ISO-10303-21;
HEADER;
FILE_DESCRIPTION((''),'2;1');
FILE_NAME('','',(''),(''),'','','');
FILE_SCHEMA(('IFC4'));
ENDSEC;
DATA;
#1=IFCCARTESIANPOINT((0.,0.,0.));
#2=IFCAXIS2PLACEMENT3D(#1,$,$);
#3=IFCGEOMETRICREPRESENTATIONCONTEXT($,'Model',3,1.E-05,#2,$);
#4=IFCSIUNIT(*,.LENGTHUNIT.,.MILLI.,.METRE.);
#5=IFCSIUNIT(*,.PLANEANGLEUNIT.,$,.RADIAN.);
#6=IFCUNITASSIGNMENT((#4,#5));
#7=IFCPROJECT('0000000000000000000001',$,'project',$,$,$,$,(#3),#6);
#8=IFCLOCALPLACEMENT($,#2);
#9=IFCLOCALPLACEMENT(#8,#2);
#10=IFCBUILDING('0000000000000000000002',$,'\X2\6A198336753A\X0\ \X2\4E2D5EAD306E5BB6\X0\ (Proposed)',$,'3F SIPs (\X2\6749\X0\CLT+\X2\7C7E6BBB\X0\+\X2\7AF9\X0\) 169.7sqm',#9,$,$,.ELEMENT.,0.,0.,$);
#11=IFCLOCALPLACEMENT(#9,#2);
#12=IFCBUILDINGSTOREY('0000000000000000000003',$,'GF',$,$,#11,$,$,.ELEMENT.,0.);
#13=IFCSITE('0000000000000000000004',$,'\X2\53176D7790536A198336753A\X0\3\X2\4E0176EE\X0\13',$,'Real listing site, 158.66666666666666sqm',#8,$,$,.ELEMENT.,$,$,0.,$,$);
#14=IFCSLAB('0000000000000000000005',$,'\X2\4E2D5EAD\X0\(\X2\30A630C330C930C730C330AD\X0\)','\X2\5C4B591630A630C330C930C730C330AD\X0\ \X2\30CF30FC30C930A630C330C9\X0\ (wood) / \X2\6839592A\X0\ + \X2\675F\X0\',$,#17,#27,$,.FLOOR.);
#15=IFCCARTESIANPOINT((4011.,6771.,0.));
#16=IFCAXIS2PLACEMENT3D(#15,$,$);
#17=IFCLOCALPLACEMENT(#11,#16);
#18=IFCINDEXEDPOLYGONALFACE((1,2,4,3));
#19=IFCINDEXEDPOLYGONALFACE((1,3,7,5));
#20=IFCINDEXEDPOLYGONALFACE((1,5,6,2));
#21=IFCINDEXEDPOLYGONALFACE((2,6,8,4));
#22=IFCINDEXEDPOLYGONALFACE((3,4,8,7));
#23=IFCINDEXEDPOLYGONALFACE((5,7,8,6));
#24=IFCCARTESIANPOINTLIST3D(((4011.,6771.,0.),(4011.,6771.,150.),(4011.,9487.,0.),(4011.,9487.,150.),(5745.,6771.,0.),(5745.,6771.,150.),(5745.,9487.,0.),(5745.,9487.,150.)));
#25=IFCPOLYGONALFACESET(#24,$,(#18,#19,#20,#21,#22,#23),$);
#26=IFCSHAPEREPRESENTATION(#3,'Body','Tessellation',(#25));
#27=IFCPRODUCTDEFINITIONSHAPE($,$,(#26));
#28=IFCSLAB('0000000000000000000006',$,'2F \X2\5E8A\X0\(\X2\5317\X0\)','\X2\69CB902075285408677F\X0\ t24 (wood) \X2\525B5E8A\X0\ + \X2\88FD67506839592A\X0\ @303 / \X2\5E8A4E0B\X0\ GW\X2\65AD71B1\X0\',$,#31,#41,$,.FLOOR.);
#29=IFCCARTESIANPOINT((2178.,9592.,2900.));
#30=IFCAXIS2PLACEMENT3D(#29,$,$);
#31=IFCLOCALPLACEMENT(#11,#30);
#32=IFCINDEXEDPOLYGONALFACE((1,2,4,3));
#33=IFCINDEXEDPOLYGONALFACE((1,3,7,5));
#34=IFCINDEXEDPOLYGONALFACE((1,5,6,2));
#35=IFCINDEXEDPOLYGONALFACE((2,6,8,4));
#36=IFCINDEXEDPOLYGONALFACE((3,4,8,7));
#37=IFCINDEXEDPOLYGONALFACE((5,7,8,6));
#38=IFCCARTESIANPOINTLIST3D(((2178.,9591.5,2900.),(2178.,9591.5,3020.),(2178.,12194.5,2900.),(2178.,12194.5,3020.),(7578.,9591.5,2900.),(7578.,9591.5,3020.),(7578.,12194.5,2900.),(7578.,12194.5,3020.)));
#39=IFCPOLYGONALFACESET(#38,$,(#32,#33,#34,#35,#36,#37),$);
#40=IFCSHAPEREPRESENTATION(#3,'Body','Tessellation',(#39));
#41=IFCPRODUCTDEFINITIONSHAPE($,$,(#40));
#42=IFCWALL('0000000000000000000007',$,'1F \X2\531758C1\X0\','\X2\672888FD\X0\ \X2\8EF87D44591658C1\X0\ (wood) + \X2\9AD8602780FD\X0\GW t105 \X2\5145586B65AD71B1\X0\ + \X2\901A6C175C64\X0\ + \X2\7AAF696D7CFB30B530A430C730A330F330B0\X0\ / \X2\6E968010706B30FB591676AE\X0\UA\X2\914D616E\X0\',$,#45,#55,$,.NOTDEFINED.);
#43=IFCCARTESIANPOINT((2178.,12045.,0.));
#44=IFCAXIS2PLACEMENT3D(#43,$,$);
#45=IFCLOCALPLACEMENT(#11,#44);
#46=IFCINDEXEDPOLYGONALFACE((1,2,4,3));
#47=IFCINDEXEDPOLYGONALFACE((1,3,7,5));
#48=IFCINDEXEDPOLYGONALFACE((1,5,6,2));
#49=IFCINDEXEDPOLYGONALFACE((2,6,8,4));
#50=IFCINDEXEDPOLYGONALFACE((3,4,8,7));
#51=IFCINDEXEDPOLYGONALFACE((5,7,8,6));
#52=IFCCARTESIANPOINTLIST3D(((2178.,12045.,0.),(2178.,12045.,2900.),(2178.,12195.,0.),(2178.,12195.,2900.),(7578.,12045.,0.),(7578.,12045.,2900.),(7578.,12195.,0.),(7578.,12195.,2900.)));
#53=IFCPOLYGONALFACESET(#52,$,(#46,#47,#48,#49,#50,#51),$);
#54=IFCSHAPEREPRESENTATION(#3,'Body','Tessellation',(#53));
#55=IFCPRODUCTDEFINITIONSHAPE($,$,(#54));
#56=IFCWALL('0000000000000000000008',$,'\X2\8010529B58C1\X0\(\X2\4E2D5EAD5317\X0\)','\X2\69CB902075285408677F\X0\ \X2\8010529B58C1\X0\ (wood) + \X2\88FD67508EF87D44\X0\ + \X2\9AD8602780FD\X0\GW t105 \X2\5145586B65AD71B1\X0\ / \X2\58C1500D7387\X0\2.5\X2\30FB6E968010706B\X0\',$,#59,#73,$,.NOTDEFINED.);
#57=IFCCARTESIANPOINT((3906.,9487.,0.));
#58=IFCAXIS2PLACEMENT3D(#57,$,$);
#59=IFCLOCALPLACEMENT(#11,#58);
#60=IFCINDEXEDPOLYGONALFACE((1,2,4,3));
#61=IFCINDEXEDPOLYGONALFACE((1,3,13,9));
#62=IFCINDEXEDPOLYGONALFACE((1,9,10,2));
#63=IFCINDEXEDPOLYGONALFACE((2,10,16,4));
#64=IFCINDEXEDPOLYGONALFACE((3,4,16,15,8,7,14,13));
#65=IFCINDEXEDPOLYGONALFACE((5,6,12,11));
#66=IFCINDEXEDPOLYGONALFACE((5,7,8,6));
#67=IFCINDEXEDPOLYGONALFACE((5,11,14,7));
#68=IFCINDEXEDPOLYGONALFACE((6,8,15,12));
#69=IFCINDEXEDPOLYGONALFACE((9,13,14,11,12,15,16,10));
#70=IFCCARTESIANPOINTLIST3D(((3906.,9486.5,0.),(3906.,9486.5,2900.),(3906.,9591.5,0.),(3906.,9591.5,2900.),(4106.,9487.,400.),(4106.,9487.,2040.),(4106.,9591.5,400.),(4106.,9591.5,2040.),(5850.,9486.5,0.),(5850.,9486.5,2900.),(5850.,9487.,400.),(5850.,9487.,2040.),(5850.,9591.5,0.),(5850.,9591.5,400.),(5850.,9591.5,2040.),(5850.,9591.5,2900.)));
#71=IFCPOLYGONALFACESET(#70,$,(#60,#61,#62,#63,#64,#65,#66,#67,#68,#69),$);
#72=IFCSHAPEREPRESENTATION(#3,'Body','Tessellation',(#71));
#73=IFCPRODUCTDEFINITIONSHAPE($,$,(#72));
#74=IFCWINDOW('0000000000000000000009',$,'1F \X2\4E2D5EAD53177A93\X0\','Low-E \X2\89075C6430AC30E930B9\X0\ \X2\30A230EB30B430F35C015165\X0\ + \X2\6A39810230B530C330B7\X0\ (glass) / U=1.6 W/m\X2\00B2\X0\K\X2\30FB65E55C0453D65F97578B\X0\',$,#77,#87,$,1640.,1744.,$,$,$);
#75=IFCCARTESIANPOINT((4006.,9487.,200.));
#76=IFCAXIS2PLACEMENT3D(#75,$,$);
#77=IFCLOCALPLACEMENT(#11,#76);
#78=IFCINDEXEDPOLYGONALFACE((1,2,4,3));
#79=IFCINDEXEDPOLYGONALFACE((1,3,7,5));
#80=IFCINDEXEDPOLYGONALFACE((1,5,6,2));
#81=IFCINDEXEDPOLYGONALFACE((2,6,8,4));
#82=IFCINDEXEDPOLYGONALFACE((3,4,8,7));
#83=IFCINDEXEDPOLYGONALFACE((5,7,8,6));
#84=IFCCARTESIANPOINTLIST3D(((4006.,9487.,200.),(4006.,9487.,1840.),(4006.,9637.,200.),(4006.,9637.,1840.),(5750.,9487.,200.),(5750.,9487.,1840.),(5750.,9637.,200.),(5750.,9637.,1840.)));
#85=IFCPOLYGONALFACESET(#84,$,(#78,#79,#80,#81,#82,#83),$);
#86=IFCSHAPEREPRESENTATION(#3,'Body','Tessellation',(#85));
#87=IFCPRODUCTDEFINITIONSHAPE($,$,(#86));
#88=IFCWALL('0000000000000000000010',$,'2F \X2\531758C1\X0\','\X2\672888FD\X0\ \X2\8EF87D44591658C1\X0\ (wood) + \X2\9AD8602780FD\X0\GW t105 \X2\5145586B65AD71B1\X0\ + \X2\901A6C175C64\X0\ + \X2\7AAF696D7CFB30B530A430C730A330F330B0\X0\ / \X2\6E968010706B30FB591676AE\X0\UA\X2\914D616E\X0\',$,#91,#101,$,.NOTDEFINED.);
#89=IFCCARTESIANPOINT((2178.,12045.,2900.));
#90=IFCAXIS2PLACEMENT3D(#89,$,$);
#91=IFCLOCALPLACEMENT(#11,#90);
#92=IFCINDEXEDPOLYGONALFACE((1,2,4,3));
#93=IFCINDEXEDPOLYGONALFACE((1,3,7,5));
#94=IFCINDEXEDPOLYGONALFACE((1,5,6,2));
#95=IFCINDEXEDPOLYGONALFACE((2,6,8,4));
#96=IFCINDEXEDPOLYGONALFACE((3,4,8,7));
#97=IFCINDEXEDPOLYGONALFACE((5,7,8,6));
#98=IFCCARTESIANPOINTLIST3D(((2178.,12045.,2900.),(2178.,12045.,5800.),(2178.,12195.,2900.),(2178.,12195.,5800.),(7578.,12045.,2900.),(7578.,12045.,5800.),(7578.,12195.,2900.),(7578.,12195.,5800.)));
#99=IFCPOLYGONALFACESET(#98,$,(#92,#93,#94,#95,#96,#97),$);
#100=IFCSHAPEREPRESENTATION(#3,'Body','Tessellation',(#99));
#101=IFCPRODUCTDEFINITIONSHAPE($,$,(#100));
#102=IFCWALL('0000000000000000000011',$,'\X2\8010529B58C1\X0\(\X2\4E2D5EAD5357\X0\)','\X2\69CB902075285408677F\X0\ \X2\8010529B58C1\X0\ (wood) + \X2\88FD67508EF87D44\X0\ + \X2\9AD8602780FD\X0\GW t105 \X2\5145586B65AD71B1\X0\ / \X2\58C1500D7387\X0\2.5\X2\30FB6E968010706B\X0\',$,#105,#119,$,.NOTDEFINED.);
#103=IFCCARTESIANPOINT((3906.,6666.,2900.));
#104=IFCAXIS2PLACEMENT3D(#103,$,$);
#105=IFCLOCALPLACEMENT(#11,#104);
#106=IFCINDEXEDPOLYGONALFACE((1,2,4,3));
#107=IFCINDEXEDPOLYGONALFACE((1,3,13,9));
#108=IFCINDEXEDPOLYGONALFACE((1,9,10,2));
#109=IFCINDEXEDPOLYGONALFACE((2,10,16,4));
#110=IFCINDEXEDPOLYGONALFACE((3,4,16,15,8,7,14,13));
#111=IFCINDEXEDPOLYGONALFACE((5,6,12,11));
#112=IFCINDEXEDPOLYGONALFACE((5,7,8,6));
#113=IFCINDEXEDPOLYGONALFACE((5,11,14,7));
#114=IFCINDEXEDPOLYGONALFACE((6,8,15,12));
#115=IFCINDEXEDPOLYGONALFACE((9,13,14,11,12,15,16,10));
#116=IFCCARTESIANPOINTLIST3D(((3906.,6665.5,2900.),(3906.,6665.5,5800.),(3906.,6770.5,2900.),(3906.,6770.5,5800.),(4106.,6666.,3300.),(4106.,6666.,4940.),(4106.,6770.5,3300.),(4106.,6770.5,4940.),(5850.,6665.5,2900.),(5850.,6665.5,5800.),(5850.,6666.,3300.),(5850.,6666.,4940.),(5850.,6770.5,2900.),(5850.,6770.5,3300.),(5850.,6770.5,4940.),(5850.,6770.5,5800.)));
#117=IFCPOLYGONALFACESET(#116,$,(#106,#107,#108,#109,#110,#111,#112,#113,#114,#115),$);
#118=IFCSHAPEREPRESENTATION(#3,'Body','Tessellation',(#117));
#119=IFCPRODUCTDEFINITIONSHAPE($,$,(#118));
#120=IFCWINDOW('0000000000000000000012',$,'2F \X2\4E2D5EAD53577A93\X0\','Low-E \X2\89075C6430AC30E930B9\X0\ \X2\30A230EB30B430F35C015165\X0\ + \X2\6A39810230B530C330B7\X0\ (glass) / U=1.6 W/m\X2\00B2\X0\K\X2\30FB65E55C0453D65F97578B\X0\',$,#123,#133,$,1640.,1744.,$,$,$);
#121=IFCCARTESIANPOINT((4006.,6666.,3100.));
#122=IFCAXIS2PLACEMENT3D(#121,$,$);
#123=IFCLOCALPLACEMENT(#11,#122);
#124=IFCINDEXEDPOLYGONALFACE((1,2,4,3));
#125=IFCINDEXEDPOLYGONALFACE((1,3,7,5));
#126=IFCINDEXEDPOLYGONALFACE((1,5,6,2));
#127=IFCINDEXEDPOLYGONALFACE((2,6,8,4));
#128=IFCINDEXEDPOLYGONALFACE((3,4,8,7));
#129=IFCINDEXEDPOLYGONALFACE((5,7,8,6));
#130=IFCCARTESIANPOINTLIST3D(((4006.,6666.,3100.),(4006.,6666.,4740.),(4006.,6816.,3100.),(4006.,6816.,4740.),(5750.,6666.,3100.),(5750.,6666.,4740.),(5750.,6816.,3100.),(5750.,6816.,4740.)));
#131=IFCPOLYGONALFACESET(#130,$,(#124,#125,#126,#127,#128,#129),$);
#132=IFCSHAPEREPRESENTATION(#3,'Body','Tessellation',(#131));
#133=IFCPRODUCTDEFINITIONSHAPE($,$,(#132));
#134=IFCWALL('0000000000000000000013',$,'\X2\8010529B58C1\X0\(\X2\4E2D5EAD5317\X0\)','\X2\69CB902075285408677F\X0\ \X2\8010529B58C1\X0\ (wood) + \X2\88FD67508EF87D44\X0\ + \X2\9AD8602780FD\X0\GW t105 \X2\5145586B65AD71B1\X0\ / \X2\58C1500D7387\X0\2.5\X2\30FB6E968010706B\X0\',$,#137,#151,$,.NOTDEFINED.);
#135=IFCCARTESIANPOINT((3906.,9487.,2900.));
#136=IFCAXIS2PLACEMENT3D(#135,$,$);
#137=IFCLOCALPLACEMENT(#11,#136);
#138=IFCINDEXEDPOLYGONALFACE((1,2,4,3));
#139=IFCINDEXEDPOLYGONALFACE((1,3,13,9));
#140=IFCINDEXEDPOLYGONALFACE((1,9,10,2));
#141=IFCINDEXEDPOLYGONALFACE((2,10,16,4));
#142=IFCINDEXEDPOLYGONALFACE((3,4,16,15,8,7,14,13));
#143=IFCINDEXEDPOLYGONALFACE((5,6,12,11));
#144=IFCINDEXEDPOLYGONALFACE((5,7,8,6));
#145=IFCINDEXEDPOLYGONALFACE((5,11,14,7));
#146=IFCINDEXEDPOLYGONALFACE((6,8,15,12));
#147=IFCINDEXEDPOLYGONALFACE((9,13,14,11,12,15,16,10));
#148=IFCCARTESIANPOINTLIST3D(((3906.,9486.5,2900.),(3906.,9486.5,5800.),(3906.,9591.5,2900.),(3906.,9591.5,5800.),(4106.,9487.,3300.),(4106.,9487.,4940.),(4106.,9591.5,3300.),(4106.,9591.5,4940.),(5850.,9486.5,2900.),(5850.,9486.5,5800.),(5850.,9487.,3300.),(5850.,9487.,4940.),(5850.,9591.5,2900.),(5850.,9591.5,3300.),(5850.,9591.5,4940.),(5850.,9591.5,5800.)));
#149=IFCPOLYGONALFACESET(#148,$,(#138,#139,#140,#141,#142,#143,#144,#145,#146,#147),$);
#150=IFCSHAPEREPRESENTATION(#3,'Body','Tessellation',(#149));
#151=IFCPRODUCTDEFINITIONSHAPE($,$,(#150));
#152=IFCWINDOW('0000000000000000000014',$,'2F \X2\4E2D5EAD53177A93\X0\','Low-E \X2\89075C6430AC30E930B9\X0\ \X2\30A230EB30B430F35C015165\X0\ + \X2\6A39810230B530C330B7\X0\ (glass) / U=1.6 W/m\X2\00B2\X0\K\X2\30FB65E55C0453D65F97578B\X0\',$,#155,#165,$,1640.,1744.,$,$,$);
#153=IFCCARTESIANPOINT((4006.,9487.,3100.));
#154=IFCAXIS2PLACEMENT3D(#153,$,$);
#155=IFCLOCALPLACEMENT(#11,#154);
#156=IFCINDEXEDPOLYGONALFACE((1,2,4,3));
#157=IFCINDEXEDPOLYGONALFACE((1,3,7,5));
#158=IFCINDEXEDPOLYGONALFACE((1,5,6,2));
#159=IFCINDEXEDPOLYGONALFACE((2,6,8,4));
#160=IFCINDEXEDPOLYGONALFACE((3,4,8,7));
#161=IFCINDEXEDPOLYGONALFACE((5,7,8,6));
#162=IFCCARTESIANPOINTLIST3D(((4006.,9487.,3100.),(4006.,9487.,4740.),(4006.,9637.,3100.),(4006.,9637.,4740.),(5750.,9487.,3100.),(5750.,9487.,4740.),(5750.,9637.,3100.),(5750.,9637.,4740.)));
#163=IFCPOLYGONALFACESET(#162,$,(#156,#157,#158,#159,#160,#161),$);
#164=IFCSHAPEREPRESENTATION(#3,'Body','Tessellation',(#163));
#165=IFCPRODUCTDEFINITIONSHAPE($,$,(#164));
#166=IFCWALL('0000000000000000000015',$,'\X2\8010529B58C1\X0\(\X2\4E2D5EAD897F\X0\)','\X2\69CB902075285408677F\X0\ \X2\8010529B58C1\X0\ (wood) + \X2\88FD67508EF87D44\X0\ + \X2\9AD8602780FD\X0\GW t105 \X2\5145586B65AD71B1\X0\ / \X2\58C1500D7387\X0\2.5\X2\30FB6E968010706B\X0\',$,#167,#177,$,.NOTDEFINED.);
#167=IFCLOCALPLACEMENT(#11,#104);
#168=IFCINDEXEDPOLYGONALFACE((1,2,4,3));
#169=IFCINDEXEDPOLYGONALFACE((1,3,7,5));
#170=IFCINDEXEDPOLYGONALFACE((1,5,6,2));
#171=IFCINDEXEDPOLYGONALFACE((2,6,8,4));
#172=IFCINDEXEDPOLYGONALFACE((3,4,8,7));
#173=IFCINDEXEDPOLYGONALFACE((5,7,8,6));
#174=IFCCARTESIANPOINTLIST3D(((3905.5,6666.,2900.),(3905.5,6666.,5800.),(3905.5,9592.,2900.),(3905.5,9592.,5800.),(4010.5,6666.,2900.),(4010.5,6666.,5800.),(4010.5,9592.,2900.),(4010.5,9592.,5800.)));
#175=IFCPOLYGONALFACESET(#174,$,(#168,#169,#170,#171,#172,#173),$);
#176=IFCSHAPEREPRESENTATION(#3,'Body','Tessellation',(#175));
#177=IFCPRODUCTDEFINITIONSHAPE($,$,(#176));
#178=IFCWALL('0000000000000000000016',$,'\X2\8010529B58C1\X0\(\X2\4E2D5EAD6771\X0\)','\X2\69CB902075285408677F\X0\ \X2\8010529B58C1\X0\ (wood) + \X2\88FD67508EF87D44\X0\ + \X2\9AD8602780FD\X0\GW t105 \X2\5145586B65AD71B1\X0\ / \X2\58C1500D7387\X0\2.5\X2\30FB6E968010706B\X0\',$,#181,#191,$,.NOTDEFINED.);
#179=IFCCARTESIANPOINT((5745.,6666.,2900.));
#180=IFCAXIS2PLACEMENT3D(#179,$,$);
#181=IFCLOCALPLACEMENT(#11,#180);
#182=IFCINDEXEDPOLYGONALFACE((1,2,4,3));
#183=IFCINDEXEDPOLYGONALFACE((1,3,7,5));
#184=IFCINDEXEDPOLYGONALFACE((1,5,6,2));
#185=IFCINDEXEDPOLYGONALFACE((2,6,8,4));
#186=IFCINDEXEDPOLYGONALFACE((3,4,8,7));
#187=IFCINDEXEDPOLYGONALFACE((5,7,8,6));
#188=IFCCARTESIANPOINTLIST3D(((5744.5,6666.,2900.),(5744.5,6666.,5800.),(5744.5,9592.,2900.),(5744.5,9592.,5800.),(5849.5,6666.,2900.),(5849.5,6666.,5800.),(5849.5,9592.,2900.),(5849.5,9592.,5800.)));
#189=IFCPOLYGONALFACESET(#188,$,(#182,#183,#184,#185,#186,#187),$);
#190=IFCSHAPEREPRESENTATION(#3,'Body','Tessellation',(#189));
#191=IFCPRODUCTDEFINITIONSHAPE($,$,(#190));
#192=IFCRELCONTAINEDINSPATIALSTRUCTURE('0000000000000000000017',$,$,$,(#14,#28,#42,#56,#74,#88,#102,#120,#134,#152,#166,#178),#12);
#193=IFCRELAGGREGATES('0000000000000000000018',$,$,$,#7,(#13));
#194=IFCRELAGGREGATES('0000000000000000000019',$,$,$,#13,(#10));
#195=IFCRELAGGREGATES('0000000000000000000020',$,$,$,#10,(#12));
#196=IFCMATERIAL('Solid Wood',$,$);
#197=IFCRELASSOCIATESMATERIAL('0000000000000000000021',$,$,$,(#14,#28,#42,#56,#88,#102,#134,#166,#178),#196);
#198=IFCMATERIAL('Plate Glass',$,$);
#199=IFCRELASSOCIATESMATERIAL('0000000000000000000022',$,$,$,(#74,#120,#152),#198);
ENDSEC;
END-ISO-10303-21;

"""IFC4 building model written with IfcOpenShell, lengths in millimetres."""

from ifc_helpers import new_model, si_unit, frame, frame_2d, origin, place, context, project, spatial, rectangle, extrude, material, element, fill, save


model = new_model("IFC4")

# Units and contexts
model_context = context("Model", 3, precision=1e-05, world=origin())
ifc_project = project(units=[si_unit("LENGTHUNIT", "METRE", prefix="MILLI"), si_unit("PLANEANGLEUNIT", "RADIAN")], contexts=[model_context])

# Site, building, storey
site_placement = place(None, origin())
site = spatial("IfcSite", under=ifc_project, at=site_placement, Name="北海道標茶町3丁目13", ObjectType="Real listing site, 158.66666666666666sqm", CompositionType="ELEMENT", RefElevation=0.0)
building_placement = place(site_placement, origin())
building = spatial("IfcBuilding", under=site, at=building_placement, Name="標茶町 中庭の家 (Proposed)", ObjectType="3F SIPs (杉CLT+籾殻+竹) 169.7sqm", CompositionType="ELEMENT", ElevationOfRefHeight=0.0, ElevationOfTerrain=0.0)
storey_placement = place(building_placement, origin())
storey = spatial("IfcBuildingStorey", under=building, at=storey_placement, Name="GF", CompositionType="ELEMENT", Elevation=0.0)

# Slabs
ifc_material_1 = material(Name="Solid Wood")
slab_1_placement = place(storey_placement, frame((4011.0, 6771.0, 0.0)))
element("IfcSlab", 1, at=slab_1_placement, inside=storey, material=ifc_material_1, Name="中庭(ウッドデッキ)", Description="屋外ウッドデッキ ハードウッド (wood) / 根太 + 束", PredefinedType="FLOOR", context=model_context, shape_type="SweptSolid", body=[
    extrude(rectangle(XDim=1734.0, YDim=2716.0, at=frame_2d((867.0, 1358.0))), frame((4011.0, 6771.0, 0.0)), (0.0, 0.0, 1.0), 150.0),
])
slab_2_placement = place(storey_placement, frame((2178.0, 9592.0, 2900.0)))
element("IfcSlab", 2, at=slab_2_placement, inside=storey, material=ifc_material_1, Name="2F 床(北)", Description="構造用合板 t24 (wood) 剛床 + 製材根太 @303 / 床下 GW断熱", PredefinedType="FLOOR", context=model_context, shape_type="SweptSolid", body=[
    extrude(rectangle(XDim=5400.0, YDim=2603.0, at=frame_2d((2700.0, 1301.0))), frame((2178.0, 9592.0, 2900.0)), (0.0, 0.0, 1.0), 120.0),
])

# Wall
wall_1_placement = place(storey_placement, frame((2178.0, 12045.0, 0.0)))
element("IfcWall", 3, at=wall_1_placement, inside=storey, material=ifc_material_1, Name="1F 北壁", Description="木製 軸組外壁 (wood) + 高性能GW t105 充填断熱 + 通気層 + 窯業系サイディング / 準耐火・外皮UA配慮", PredefinedType="NOTDEFINED", context=model_context, shape_type="SweptSolid", body=[
    extrude(rectangle(XDim=5400.0, YDim=150.0, at=frame_2d((2700.0, 75.0))), frame((2178.0, 12045.0, 0.0)), (0.0, 0.0, 1.0), 2900.0),
])

# Wall, opening, window
wall_2_placement = place(storey_placement, frame((3906.0, 9487.0, 0.0)))
wall_2 = element("IfcWall", 4, at=wall_2_placement, inside=storey, material=ifc_material_1, Name="耐力壁(中庭北)", Description="構造用合板 耐力壁 (wood) + 製材軸組 + 高性能GW t105 充填断熱 / 壁倍率2.5・準耐火", PredefinedType="NOTDEFINED", context=model_context, shape_type="SweptSolid", body=[
    extrude(rectangle(XDim=1944.0, YDim=105.0, at=frame_2d((972.0, 52.0))), frame((3906.0, 9487.0, 0.0)), (0.0, 0.0, 1.0), 2900.0),
])
opening_1_placement = place(storey_placement, frame((4006.0, 9487.0, 200.0)))
opening_1 = element("IfcOpeningElement", 5, at=opening_1_placement, cuts=wall_2, PredefinedType="NOTDEFINED", context=model_context, shape_type="SweptSolid", body=[
    extrude(rectangle(XDim=1744.0, YDim=150.0, at=frame_2d((872.0, 75.0))), frame((4006.0, 9487.0, 200.0)), (0.0, 0.0, 1.0), 1640.0),
])
ifc_material_2 = material(Name="Plate Glass")
window_1_placement = place(storey_placement, frame((4006.0, 9487.0, 200.0)))
window_1 = element("IfcWindow", 6, at=window_1_placement, inside=storey, material=ifc_material_2, Name="1F 中庭北窓", Description="Low-E 複層ガラス アルゴン封入 + 樹脂サッシ (glass) / U=1.6 W/m²K・日射取得型", OverallHeight=1640.0, OverallWidth=1744.0, context=model_context, shape_type="SweptSolid", body=[
    extrude(rectangle(XDim=1744.0, YDim=150.0, at=frame_2d((872.0, 75.0))), frame((4006.0, 9487.0, 200.0)), (0.0, 0.0, 1.0), 1640.0),
])
fill(opening_1, window_1)

# Wall
wall_3_placement = place(storey_placement, frame((2178.0, 12045.0, 2900.0)))
element("IfcWall", 7, at=wall_3_placement, inside=storey, material=ifc_material_1, Name="2F 北壁", Description="木製 軸組外壁 (wood) + 高性能GW t105 充填断熱 + 通気層 + 窯業系サイディング / 準耐火・外皮UA配慮", PredefinedType="NOTDEFINED", context=model_context, shape_type="SweptSolid", body=[
    extrude(rectangle(XDim=5400.0, YDim=150.0, at=frame_2d((2700.0, 75.0))), frame((2178.0, 12045.0, 2900.0)), (0.0, 0.0, 1.0), 2900.0),
])

# Walls, openings, windows
wall_4_placement = place(storey_placement, frame((3906.0, 6666.0, 2900.0)))
wall_4 = element("IfcWall", 8, at=wall_4_placement, inside=storey, material=ifc_material_1, Name="耐力壁(中庭南)", Description="構造用合板 耐力壁 (wood) + 製材軸組 + 高性能GW t105 充填断熱 / 壁倍率2.5・準耐火", PredefinedType="NOTDEFINED", context=model_context, shape_type="SweptSolid", body=[
    extrude(rectangle(XDim=1944.0, YDim=105.0, at=frame_2d((972.0, 52.0))), frame((3906.0, 6666.0, 2900.0)), (0.0, 0.0, 1.0), 2900.0),
])
opening_2_placement = place(storey_placement, frame((4006.0, 6666.0, 3100.0)))
opening_2 = element("IfcOpeningElement", 9, at=opening_2_placement, cuts=wall_4, PredefinedType="NOTDEFINED", context=model_context, shape_type="SweptSolid", body=[
    extrude(rectangle(XDim=1744.0, YDim=150.0, at=frame_2d((872.0, 75.0))), frame((4006.0, 6666.0, 3100.0)), (0.0, 0.0, 1.0), 1640.0),
])
window_2_placement = place(storey_placement, frame((4006.0, 6666.0, 3100.0)))
window_2 = element("IfcWindow", 10, at=window_2_placement, inside=storey, material=ifc_material_2, Name="2F 中庭南窓", Description="Low-E 複層ガラス アルゴン封入 + 樹脂サッシ (glass) / U=1.6 W/m²K・日射取得型", OverallHeight=1640.0, OverallWidth=1744.0, context=model_context, shape_type="SweptSolid", body=[
    extrude(rectangle(XDim=1744.0, YDim=150.0, at=frame_2d((872.0, 75.0))), frame((4006.0, 6666.0, 3100.0)), (0.0, 0.0, 1.0), 1640.0),
])
fill(opening_2, window_2)
wall_5_placement = place(storey_placement, frame((3906.0, 9487.0, 2900.0)))
wall_5 = element("IfcWall", 11, at=wall_5_placement, inside=storey, material=ifc_material_1, Name="耐力壁(中庭北)", Description="構造用合板 耐力壁 (wood) + 製材軸組 + 高性能GW t105 充填断熱 / 壁倍率2.5・準耐火", PredefinedType="NOTDEFINED", context=model_context, shape_type="SweptSolid", body=[
    extrude(rectangle(XDim=1944.0, YDim=105.0, at=frame_2d((972.0, 52.0))), frame((3906.0, 9487.0, 2900.0)), (0.0, 0.0, 1.0), 2900.0),
])
opening_3_placement = place(storey_placement, frame((4006.0, 9487.0, 3100.0)))
opening_3 = element("IfcOpeningElement", 12, at=opening_3_placement, cuts=wall_5, PredefinedType="NOTDEFINED", context=model_context, shape_type="SweptSolid", body=[
    extrude(rectangle(XDim=1744.0, YDim=150.0, at=frame_2d((872.0, 75.0))), frame((4006.0, 9487.0, 3100.0)), (0.0, 0.0, 1.0), 1640.0),
])
window_3_placement = place(storey_placement, frame((4006.0, 9487.0, 3100.0)))
window_3 = element("IfcWindow", 13, at=window_3_placement, inside=storey, material=ifc_material_2, Name="2F 中庭北窓", Description="Low-E 複層ガラス アルゴン封入 + 樹脂サッシ (glass) / U=1.6 W/m²K・日射取得型", OverallHeight=1640.0, OverallWidth=1744.0, context=model_context, shape_type="SweptSolid", body=[
    extrude(rectangle(XDim=1744.0, YDim=150.0, at=frame_2d((872.0, 75.0))), frame((4006.0, 9487.0, 3100.0)), (0.0, 0.0, 1.0), 1640.0),
])
fill(opening_3, window_3)

# Walls
wall_6_placement = place(storey_placement, frame((3906.0, 6666.0, 2900.0)))
element("IfcWall", 14, at=wall_6_placement, inside=storey, material=ifc_material_1, Name="耐力壁(中庭西)", Description="構造用合板 耐力壁 (wood) + 製材軸組 + 高性能GW t105 充填断熱 / 壁倍率2.5・準耐火", PredefinedType="NOTDEFINED", context=model_context, shape_type="SweptSolid", body=[
    extrude(rectangle(XDim=105.0, YDim=2926.0, at=frame_2d((52.0, 1463.0))), frame((3906.0, 6666.0, 2900.0)), (0.0, 0.0, 1.0), 2900.0),
])
wall_7_placement = place(storey_placement, frame((5745.0, 6666.0, 2900.0)))
element("IfcWall", 15, at=wall_7_placement, inside=storey, material=ifc_material_1, Name="耐力壁(中庭東)", Description="構造用合板 耐力壁 (wood) + 製材軸組 + 高性能GW t105 充填断熱 / 壁倍率2.5・準耐火", PredefinedType="NOTDEFINED", context=model_context, shape_type="SweptSolid", body=[
    extrude(rectangle(XDim=105.0, YDim=2926.0, at=frame_2d((52.0, 1463.0))), frame((5745.0, 6666.0, 2900.0)), (0.0, 0.0, 1.0), 2900.0),
])

save(model, "model.ifc")
